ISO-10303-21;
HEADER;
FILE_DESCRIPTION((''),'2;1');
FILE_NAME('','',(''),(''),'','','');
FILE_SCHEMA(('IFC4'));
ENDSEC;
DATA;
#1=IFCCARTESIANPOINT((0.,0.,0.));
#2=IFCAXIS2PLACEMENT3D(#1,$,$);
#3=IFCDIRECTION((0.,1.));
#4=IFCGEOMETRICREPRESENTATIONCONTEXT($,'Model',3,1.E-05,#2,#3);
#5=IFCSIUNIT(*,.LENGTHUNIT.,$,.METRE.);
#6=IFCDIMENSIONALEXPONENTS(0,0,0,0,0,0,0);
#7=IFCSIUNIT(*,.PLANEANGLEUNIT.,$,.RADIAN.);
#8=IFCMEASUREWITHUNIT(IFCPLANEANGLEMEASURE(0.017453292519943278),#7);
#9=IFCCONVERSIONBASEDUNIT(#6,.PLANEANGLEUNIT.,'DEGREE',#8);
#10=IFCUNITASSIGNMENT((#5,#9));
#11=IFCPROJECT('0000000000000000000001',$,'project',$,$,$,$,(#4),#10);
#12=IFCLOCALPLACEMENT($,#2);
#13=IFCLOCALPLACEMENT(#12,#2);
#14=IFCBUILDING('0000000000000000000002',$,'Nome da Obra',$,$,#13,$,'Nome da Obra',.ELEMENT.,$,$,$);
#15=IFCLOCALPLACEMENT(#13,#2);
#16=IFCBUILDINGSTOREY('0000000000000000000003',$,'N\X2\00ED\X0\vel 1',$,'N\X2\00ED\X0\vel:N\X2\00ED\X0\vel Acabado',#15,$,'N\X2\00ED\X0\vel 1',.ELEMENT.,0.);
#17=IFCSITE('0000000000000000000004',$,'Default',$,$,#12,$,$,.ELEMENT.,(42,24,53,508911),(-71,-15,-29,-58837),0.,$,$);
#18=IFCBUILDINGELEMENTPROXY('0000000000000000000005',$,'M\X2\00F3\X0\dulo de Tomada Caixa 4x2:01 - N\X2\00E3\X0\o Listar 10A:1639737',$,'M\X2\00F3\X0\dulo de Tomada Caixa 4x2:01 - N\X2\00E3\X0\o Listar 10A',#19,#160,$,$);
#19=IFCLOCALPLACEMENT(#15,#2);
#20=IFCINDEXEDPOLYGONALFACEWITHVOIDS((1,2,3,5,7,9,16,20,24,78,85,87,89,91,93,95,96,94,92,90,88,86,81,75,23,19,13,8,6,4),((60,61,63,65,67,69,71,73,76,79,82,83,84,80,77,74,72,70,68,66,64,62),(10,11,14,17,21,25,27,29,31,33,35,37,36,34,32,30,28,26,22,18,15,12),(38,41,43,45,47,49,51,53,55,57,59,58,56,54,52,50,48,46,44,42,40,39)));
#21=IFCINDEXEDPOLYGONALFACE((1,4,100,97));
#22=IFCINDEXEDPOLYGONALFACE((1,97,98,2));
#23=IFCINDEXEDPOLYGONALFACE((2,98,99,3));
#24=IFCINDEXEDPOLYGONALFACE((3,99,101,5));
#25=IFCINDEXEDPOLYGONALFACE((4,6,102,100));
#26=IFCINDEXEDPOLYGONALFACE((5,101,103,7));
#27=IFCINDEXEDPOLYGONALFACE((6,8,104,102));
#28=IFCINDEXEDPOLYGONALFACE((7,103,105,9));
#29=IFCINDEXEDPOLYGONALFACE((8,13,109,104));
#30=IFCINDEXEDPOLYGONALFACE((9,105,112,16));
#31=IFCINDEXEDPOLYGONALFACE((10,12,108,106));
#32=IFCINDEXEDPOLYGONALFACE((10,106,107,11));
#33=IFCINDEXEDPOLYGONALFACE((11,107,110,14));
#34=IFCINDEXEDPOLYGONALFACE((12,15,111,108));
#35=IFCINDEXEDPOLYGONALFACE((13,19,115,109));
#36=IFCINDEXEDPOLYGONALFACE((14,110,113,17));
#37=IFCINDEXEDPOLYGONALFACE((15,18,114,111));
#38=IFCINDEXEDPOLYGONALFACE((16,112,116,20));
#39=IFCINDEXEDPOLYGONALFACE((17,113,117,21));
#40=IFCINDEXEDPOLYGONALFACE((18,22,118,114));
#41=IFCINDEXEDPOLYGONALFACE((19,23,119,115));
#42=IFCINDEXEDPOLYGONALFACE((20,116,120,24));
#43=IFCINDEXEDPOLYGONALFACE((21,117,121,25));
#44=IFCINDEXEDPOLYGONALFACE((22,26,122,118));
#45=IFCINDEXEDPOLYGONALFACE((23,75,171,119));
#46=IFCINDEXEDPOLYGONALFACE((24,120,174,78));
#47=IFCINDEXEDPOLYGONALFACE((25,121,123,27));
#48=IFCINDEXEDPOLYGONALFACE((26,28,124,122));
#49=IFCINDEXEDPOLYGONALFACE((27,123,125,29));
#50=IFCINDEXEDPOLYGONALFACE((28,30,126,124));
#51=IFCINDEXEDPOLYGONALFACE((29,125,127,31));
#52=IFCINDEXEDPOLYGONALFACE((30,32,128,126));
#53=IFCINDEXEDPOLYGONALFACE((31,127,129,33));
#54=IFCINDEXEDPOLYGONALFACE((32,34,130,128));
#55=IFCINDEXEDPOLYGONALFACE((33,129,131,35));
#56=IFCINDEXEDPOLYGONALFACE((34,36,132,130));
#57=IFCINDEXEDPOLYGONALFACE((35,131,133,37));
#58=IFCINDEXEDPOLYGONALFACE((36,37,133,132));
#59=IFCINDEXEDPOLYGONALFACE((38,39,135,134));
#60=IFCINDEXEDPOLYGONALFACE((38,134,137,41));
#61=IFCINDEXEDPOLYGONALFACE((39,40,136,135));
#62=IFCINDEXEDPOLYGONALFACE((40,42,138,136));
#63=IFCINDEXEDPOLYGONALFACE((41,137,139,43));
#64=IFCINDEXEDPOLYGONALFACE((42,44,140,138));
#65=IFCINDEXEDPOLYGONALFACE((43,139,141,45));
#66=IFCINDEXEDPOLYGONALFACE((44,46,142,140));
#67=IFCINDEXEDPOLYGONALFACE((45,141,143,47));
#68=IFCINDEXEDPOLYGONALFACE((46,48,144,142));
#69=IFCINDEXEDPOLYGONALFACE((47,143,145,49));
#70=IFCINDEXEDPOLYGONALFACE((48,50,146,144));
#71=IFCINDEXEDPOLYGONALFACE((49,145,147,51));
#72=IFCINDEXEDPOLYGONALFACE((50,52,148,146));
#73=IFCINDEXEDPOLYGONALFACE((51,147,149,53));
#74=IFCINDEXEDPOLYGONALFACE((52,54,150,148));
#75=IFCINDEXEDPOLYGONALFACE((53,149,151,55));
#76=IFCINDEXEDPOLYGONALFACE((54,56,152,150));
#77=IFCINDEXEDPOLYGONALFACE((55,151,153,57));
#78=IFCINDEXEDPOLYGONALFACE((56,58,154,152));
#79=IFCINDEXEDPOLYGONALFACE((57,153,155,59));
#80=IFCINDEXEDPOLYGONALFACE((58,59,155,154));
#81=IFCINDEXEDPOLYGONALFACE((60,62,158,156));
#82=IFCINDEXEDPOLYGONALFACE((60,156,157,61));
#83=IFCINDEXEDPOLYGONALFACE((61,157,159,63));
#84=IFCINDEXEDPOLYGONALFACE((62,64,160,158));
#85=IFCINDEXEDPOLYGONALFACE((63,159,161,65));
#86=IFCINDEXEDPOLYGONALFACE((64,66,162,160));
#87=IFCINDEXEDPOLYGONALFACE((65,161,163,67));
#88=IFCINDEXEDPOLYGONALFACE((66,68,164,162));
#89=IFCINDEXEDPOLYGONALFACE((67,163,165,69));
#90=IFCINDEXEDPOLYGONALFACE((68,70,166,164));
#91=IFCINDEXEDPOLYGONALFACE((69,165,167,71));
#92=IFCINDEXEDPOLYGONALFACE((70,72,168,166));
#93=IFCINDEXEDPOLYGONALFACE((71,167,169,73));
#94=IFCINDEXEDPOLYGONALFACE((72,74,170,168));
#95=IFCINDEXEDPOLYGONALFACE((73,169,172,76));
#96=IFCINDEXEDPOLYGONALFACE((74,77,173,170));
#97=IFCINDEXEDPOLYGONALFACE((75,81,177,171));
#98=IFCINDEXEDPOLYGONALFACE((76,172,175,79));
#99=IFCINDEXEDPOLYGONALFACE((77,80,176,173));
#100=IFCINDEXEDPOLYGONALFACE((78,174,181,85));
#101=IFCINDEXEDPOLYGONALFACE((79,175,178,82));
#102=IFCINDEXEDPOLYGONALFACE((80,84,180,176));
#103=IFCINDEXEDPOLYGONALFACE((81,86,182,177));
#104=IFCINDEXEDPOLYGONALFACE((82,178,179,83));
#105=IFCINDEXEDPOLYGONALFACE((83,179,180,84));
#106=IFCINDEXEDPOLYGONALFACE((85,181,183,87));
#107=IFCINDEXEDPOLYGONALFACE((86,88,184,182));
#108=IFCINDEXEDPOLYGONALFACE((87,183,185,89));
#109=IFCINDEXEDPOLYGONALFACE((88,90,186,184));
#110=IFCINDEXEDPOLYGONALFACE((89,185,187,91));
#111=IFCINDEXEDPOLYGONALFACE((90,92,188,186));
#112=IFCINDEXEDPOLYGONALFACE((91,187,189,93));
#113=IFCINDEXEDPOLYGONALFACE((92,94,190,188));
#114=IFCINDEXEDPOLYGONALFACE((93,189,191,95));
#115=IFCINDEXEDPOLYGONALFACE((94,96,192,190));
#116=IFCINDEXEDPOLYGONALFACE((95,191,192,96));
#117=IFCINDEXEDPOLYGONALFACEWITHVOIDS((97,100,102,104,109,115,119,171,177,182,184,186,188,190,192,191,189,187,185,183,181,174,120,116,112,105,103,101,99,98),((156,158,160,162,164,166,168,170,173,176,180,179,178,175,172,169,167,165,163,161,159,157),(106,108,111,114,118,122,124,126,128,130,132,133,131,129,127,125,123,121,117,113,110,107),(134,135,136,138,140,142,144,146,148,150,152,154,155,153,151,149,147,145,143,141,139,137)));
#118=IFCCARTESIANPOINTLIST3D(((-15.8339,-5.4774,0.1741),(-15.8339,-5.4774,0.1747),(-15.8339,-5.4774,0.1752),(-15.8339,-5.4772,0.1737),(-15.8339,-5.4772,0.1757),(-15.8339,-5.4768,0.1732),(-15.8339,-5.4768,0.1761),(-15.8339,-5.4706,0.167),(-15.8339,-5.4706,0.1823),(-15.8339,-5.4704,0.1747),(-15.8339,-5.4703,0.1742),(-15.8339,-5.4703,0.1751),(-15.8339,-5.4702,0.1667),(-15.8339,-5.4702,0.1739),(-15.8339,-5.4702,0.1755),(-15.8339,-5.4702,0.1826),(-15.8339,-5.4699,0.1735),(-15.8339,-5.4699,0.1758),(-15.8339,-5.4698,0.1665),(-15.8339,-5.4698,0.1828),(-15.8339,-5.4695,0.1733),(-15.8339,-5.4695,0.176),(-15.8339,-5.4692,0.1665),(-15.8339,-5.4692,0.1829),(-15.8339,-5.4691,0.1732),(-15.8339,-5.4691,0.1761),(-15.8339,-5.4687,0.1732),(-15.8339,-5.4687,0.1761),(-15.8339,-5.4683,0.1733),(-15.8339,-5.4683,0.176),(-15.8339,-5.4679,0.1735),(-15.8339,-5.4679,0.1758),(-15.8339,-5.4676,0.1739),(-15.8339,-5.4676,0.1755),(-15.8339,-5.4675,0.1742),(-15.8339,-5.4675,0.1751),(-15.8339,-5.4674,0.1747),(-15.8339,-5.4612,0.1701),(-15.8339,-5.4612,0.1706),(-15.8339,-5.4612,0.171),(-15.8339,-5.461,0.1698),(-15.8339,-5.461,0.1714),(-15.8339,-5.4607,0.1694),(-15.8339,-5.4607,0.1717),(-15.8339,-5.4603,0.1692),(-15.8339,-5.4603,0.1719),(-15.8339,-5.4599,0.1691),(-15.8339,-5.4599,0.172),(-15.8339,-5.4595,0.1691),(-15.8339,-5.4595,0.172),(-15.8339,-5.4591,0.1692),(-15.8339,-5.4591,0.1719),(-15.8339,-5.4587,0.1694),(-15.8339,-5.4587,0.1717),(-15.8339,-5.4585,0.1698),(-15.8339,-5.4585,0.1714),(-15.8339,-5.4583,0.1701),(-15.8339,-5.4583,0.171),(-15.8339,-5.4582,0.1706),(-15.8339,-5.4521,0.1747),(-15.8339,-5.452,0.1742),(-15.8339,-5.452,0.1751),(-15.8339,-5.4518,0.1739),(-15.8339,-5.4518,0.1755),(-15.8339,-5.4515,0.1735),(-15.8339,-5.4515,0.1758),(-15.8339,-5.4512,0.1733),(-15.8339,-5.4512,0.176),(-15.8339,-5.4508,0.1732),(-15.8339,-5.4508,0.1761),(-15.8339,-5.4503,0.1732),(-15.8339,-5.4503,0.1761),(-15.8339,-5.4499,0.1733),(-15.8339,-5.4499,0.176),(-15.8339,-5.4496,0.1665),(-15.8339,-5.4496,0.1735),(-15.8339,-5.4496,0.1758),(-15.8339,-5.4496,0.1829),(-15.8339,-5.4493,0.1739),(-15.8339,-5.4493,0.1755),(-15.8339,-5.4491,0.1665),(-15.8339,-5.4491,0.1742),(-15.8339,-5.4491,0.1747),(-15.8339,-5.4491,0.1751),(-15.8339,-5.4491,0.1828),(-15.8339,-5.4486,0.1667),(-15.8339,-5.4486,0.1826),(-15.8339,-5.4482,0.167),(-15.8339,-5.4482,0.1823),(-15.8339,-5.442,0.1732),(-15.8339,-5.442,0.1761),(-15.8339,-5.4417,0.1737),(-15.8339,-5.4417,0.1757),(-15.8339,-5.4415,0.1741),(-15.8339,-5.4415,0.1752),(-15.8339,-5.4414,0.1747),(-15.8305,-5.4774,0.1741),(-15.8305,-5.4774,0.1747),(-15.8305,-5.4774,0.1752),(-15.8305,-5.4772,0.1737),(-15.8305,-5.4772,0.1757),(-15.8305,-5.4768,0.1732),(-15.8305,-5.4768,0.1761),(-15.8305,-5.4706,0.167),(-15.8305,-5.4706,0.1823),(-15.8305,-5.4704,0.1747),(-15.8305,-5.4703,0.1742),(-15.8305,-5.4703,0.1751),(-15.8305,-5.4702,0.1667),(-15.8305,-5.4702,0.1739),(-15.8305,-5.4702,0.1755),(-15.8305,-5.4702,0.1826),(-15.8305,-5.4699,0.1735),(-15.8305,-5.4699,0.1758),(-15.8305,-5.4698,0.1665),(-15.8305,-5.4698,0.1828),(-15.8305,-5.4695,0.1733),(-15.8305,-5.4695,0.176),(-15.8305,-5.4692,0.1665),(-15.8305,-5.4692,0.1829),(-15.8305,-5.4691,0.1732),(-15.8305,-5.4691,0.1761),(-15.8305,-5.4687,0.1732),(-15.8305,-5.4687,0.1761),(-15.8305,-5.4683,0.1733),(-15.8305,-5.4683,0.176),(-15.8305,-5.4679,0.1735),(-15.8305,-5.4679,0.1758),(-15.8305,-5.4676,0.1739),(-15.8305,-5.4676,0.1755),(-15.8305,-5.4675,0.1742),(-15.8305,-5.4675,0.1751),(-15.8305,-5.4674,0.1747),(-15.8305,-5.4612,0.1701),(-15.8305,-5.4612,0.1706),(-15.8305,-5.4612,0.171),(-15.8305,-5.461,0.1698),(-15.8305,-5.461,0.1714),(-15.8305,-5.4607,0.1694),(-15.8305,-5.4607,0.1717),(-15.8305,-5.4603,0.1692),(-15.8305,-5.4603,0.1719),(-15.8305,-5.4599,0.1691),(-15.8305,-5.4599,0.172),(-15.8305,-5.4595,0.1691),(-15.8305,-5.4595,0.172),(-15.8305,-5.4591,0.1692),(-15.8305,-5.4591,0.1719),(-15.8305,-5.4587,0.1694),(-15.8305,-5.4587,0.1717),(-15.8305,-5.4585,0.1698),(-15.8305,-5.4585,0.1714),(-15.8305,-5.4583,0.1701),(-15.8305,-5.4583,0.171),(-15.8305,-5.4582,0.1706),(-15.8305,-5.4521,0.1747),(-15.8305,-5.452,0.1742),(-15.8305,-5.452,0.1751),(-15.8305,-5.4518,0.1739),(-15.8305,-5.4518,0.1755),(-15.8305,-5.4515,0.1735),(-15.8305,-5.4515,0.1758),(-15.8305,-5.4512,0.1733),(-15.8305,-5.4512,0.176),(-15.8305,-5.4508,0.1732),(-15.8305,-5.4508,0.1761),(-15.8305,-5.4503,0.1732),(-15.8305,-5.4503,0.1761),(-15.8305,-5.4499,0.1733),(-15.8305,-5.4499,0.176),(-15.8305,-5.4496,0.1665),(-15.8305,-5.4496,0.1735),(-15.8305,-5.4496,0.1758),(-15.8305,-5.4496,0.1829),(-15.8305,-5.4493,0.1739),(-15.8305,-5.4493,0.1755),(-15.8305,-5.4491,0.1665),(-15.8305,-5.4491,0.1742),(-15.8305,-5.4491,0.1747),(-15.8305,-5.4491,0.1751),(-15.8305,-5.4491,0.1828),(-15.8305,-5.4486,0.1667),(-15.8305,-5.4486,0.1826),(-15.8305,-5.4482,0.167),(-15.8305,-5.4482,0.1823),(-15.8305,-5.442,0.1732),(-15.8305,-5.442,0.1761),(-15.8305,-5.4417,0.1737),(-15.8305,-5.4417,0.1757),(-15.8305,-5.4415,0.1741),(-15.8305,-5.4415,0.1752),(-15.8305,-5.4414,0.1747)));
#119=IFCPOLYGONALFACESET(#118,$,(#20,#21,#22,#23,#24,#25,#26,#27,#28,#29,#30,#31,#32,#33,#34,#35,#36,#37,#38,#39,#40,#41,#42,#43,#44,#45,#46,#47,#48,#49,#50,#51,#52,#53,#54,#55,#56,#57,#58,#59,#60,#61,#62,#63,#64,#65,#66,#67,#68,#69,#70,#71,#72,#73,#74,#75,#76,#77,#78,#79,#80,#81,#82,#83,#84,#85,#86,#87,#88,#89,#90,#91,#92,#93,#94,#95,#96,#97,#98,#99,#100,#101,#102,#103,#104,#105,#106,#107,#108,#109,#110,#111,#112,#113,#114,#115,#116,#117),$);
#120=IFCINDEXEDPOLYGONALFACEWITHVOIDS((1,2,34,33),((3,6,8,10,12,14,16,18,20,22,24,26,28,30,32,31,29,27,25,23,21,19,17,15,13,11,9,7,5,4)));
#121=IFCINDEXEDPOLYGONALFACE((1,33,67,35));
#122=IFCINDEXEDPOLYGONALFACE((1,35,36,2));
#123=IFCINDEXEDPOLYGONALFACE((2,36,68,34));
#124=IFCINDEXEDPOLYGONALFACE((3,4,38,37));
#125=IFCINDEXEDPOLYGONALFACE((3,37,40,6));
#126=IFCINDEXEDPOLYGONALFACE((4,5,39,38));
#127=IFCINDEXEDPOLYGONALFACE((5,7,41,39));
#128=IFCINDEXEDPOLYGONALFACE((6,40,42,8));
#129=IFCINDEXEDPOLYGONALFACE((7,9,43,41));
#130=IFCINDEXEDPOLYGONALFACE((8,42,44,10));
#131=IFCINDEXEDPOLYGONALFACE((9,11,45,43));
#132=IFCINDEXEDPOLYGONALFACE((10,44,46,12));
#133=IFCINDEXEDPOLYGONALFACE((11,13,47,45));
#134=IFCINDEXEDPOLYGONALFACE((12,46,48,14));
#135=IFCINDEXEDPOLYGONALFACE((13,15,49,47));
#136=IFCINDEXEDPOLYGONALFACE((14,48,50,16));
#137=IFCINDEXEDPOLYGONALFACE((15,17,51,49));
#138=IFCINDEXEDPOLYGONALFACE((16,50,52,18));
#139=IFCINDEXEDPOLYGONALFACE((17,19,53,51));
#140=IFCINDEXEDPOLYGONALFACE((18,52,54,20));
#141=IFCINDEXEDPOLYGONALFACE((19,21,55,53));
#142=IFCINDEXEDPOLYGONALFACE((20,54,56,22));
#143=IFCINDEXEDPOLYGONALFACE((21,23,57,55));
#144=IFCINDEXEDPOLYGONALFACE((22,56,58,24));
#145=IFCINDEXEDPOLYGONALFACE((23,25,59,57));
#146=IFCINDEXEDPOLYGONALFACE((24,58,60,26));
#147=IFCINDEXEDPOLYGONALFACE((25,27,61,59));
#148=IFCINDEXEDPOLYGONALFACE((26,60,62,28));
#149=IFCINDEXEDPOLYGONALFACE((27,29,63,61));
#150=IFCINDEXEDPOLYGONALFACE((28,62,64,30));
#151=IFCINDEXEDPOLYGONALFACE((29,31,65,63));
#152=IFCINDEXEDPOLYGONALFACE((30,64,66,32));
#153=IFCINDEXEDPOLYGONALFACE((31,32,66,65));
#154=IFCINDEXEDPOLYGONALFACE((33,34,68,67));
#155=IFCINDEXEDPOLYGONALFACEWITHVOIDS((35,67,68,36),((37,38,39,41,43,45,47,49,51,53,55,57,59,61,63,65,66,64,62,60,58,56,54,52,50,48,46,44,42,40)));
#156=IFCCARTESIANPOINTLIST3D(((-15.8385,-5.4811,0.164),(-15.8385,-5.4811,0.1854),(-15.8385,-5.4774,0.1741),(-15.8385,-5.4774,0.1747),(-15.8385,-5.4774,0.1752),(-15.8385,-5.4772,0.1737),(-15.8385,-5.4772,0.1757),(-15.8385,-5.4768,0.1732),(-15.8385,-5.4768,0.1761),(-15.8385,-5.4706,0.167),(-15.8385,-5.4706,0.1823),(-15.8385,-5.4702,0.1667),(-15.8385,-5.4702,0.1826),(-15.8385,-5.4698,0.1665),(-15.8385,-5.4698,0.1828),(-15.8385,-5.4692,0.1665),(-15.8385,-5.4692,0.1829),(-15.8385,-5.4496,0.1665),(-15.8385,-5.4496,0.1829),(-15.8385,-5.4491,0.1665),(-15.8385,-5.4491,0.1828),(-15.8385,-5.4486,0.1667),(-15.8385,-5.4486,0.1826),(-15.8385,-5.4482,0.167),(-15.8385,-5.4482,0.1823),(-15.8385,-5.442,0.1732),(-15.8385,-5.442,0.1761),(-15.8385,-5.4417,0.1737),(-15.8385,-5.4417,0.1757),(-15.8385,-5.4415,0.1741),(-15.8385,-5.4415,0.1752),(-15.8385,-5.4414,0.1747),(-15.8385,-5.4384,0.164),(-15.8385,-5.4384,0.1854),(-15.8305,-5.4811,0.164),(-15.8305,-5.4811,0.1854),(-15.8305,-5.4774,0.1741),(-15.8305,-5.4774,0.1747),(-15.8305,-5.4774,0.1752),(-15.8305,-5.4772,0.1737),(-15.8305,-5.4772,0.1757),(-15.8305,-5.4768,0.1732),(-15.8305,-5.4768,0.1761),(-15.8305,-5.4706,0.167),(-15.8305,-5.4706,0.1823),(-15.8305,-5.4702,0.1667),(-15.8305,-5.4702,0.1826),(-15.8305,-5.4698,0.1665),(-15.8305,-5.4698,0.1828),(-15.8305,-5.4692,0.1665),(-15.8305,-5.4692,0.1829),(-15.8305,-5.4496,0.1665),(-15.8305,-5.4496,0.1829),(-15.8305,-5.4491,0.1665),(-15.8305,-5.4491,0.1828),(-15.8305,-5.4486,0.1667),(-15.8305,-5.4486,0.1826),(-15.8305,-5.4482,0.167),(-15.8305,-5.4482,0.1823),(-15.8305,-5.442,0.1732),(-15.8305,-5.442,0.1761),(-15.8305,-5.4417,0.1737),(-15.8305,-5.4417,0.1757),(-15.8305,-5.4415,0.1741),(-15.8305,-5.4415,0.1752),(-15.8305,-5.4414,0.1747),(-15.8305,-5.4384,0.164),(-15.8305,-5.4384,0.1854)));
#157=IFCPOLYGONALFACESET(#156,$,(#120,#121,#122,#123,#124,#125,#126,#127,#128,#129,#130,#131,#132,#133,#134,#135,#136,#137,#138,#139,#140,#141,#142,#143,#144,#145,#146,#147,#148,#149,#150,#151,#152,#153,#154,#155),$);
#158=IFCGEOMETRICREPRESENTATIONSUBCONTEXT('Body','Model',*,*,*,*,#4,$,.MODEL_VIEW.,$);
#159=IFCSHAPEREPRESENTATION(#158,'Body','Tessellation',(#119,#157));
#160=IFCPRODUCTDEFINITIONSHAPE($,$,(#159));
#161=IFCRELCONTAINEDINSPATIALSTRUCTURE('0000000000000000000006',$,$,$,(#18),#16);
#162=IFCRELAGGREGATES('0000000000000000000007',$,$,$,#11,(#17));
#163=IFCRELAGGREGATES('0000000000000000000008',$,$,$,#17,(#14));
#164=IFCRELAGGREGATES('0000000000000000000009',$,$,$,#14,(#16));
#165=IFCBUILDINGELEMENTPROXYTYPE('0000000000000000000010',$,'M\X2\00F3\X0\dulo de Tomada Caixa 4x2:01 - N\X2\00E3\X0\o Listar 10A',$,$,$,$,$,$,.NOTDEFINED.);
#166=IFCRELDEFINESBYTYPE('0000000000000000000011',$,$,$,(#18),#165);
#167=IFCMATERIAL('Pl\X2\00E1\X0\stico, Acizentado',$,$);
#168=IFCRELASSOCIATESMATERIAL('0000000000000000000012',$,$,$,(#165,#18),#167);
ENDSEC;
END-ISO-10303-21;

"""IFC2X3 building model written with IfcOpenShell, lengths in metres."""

from ifc_helpers import new_model, entity, si_unit, converted_unit, direction, frame, frame_2d, origin, place, context, subcontext, project, spatial, polyline, circle_curve, parameter, trimmed, segment, composite_curve, outline, extrude, source, transform, mapped, material, type_object, type_shapes, element, save


model = new_model("IFC2X3")

# Units and contexts
model_context = context("Model", 3, precision=1e-05, world=origin(), true_north=direction((0.0, 1.0)))
body_context = subcontext(model_context, "Body", "Model", "MODEL_VIEW")
ifc_project = project(units=[si_unit("LENGTHUNIT", "METRE"), converted_unit("PLANEANGLEUNIT", "DEGREE", entity("IfcPlaneAngleMeasure", 0.017453292519943278), si_unit("PLANEANGLEUNIT", "RADIAN"), dimensions=[0, 0, 0, 0, 0, 0, 0])], contexts=[model_context])

# Site, building, storey
site_placement = place(None, origin())
site = spatial("IfcSite", under=ifc_project, at=site_placement, Name="Default", CompositionType="ELEMENT", RefLatitude=(42, 24, 53, 508911), RefLongitude=(-71, -15, -29, -58837), RefElevation=0.0)
building_placement = place(site_placement, origin())
building = spatial("IfcBuilding", under=site, at=building_placement, Name="Nome da Obra", LongName="Nome da Obra", CompositionType="ELEMENT")
storey_placement = place(building_placement, origin())
storey = spatial("IfcBuildingStorey", under=building, at=storey_placement, Name="Nível 1", ObjectType="Nível:Nível Acabado", LongName="Nível 1", CompositionType="ELEMENT", Elevation=0.0)

# Building element proxy
ifc_material_1 = material(Name="Plástico, Acizentado")
building_element_proxy_type_1 = type_object("IfcBuildingElementProxyType", Name="Módulo de Tomada Caixa 4x2:01 - Não Listar 10A", PredefinedType="NOTDEFINED", material=ifc_material_1)
shared_shape_1 = source(origin(), body_context, "Body", "SweptSolid", [
    extrude(outline(composite_curve([segment(polyline([(-0.0098, -0.0082), (0.0098, -0.0082)]), True, "CONTINUOUS"), segment(trimmed(circle_curve(frame_2d((0.0098, -0.0062), x_axis=(1.0, 0.0)), 0.002), [parameter(270.0)], [parameter(315.0)], True, "PARAMETER"), True, "CONTINUOUS"), segment(polyline([(0.0112, -0.0076), (0.0174, -0.0014)]), True, "CONTINUOUS"), segment(trimmed(circle_curve(frame_2d((0.016, 0.0), x_axis=(1.0, 0.0)), 0.002), [parameter(315.0)], [parameter(45.0)], True, "PARAMETER"), True, "CONTINUOUS"), segment(polyline([(0.0174, 0.0014), (0.0112, 0.0076)]), True, "CONTINUOUS"), segment(trimmed(circle_curve(frame_2d((0.0098, 0.0062), x_axis=(1.0, 0.0)), 0.002), [parameter(45.0)], [parameter(90.0)], True, "PARAMETER"), True, "CONTINUOUS"), segment(polyline([(0.0098, 0.0082), (-0.0098, 0.0082)]), True, "CONTINUOUS"), segment(trimmed(circle_curve(frame_2d((-0.0098, 0.0062), x_axis=(1.0, 0.0)), 0.002), [parameter(90.0)], [parameter(135.0)], True, "PARAMETER"), True, "CONTINUOUS"), segment(polyline([(-0.0112, 0.0076), (-0.0174, 0.0014)]), True, "CONTINUOUS"), segment(trimmed(circle_curve(frame_2d((-0.016, 0.0), x_axis=(1.0, 0.0)), 0.002), [parameter(135.0)], [parameter(225.0)], True, "PARAMETER"), True, "CONTINUOUS"), segment(polyline([(-0.0174, -0.0014), (-0.0112, -0.0076)]), True, "CONTINUOUS"), segment(trimmed(circle_curve(frame_2d((-0.0098, -0.0062), x_axis=(1.0, 0.0)), 0.002), [parameter(225.0)], [parameter(270.0)], True, "PARAMETER"), True, "CONTINUOUS")], self_intersect=False), holes=[composite_curve([segment(trimmed(circle_curve(frame_2d((0.0089, 0.0), x_axis=(1.0, 0.0)), 0.0015), [parameter(0.0)], [parameter(180.0)], True, "PARAMETER"), False, "CONTINUOUS"), segment(trimmed(circle_curve(frame_2d((0.0089, 0.0), x_axis=(1.0, 0.0)), 0.0015), [parameter(180.0)], [parameter(0.0)], True, "PARAMETER"), False, "CONTINUOUS")], self_intersect=False), composite_curve([segment(trimmed(circle_curve(frame_2d((-0.0003, 0.0041), x_axis=(1.0, 0.0)), 0.0015), [parameter(0.0)], [parameter(180.0)], True, "PARAMETER"), False, "CONTINUOUS"), segment(trimmed(circle_curve(frame_2d((-0.0003, 0.0041), x_axis=(1.0, 0.0)), 0.0015), [parameter(180.0)], [parameter(0.0)], True, "PARAMETER"), False, "CONTINUOUS")], self_intersect=False), composite_curve([segment(trimmed(circle_curve(frame_2d((-0.0095, 0.0), x_axis=(1.0, 0.0)), 0.0015), [parameter(0.0)], [parameter(180.0)], True, "PARAMETER"), False, "CONTINUOUS"), segment(trimmed(circle_curve(frame_2d((-0.0095, 0.0), x_axis=(1.0, 0.0)), 0.0015), [parameter(180.0)], [parameter(0.0)], True, "PARAMETER"), False, "CONTINUOUS")], self_intersect=False)]), frame((0.0003, 0.0, 0.125), z_axis=(0.0, 1.0, 0.0), x_axis=(1.0, 0.0, 0.0)), (0.0, 0.0, 1.0), 0.0034),
    extrude(outline(polyline([(-0.0214, -0.0107), (0.0214, -0.0107), (0.0214, 0.0107), (-0.0214, 0.0107), (-0.0214, -0.0107)]), holes=[composite_curve([segment(polyline([(0.0101, -0.0082), (-0.0095, -0.0082)]), True, "CONTINUOUS"), segment(trimmed(circle_curve(frame_2d((-0.0095, -0.0062), x_axis=(1.0, 0.0)), 0.002), [parameter(225.0)], [parameter(270.0)], True, "PARAMETER"), False, "CONTINUOUS"), segment(polyline([(-0.0109, -0.0076), (-0.0171, -0.0014)]), True, "CONTINUOUS"), segment(trimmed(circle_curve(frame_2d((-0.0157, 0.0), x_axis=(1.0, 0.0)), 0.002), [parameter(135.0)], [parameter(225.0)], True, "PARAMETER"), False, "CONTINUOUS"), segment(polyline([(-0.0171, 0.0014), (-0.0109, 0.0076)]), True, "CONTINUOUS"), segment(trimmed(circle_curve(frame_2d((-0.0095, 0.0062), x_axis=(1.0, 0.0)), 0.002), [parameter(90.0)], [parameter(135.0)], True, "PARAMETER"), False, "CONTINUOUS"), segment(polyline([(-0.0095, 0.0082), (0.0101, 0.0082)]), True, "CONTINUOUS"), segment(trimmed(circle_curve(frame_2d((0.0101, 0.0062), x_axis=(1.0, 0.0)), 0.002), [parameter(45.0)], [parameter(90.0)], True, "PARAMETER"), False, "CONTINUOUS"), segment(polyline([(0.0115, 0.0076), (0.0177, 0.0014)]), True, "CONTINUOUS"), segment(trimmed(circle_curve(frame_2d((0.0163, 0.0), x_axis=(1.0, 0.0)), 0.002), [parameter(315.0)], [parameter(45.0)], True, "PARAMETER"), False, "CONTINUOUS"), segment(polyline([(0.0177, -0.0014), (0.0115, -0.0076)]), True, "CONTINUOUS"), segment(trimmed(circle_curve(frame_2d((0.0101, -0.0062), x_axis=(1.0, 0.0)), 0.002), [parameter(270.0)], [parameter(315.0)], True, "PARAMETER"), False, "CONTINUOUS")], self_intersect=False)]), frame((0.0, 0.0, 0.125), z_axis=(0.0, 1.0, 0.0), x_axis=(1.0, 0.0, 0.0)), (0.0, 0.0, 1.0), 0.008),
])
type_shapes(building_element_proxy_type_1, [shared_shape_1])
for number, where, z_axis, x_axis, name in (
    (1, (-15.8305, -5.4597, 0.0497), (0.0, 0.0, 1.0), (0.0, 1.0, 0.0), "Módulo de Tomada Caixa 4x2:01 - Não Listar 10A:1639737"),
):
    element("IfcBuildingElementProxy", number, at=place(storey_placement, frame(where, z_axis=z_axis, x_axis=x_axis)), inside=storey, type_object=building_element_proxy_type_1, material=ifc_material_1, Name=name, ObjectType="Módulo de Tomada Caixa 4x2:01 - Não Listar 10A", context=body_context, shape_type="MappedRepresentation", body=[
        mapped(shared_shape_1, transform((0.0, 0.0, 0.0), scale=1.0)),
    ])

save(model, "model.ifc")
